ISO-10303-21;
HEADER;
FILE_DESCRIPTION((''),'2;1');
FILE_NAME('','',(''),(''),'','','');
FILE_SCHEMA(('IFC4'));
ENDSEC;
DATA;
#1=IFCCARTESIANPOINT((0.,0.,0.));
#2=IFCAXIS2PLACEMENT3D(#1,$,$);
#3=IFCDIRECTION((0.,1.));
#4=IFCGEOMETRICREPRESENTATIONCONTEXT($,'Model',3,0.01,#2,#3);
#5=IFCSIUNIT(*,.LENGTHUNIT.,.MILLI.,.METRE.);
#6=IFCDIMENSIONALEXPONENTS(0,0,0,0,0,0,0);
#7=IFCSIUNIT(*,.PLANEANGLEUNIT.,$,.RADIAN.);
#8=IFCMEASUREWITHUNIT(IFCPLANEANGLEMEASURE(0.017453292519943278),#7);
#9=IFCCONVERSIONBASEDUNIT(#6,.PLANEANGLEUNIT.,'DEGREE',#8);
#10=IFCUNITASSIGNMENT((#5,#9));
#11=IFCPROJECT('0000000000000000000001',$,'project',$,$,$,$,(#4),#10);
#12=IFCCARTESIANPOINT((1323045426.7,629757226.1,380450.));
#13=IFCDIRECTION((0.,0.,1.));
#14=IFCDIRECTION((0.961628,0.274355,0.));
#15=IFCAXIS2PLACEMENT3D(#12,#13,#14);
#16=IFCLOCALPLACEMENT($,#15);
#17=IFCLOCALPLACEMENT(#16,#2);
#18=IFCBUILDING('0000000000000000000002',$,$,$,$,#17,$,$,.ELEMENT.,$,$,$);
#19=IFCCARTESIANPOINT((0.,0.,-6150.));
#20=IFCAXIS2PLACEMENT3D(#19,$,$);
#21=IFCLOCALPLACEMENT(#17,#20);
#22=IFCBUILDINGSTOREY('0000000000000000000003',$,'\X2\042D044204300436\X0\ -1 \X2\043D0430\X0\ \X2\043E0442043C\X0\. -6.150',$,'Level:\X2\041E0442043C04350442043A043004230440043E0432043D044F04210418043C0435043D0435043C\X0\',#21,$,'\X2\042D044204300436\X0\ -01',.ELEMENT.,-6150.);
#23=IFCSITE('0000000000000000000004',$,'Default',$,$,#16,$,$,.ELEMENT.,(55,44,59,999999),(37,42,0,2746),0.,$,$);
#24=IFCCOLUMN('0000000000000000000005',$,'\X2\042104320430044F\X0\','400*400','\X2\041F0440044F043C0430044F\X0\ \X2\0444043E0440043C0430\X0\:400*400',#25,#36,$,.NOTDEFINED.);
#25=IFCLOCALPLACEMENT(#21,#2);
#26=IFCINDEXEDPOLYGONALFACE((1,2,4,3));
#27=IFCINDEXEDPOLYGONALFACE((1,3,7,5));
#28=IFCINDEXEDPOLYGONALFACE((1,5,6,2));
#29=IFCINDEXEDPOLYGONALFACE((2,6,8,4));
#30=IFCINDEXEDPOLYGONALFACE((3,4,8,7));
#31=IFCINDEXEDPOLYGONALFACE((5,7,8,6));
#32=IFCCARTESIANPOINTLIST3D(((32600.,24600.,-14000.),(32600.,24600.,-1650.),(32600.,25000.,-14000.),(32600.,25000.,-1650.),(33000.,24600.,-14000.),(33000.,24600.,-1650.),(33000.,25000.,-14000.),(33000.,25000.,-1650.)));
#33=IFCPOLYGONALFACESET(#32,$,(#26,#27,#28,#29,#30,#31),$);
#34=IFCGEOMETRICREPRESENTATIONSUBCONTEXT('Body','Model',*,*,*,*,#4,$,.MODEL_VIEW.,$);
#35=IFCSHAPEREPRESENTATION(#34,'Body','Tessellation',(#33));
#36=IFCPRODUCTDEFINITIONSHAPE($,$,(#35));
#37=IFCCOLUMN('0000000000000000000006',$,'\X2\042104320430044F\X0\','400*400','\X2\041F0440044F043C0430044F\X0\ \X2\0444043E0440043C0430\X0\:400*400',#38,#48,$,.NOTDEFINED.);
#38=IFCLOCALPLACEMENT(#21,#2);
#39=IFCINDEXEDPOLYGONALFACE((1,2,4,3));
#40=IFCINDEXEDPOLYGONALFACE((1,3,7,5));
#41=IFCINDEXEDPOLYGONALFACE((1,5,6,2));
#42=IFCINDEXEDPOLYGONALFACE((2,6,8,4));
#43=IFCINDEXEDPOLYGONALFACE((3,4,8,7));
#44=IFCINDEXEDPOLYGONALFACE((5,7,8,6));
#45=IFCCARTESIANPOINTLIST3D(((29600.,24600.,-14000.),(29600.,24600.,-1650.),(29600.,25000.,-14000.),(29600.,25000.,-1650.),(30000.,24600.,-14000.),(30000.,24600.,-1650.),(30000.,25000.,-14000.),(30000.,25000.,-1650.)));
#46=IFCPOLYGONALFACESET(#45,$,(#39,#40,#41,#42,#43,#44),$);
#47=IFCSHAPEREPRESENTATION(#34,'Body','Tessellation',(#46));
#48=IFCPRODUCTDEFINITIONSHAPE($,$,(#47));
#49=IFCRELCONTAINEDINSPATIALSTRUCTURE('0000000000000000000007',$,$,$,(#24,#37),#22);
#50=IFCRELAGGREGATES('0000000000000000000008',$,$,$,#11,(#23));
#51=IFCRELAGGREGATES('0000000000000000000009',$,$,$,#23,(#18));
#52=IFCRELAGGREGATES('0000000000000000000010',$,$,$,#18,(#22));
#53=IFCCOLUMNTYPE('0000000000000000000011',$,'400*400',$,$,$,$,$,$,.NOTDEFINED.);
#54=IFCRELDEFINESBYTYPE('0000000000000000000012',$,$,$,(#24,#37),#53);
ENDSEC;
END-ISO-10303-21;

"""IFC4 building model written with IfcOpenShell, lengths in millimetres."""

from ifc_helpers import new_model, entity, si_unit, converted_unit, direction, frame, origin, place, context, subcontext, project, spatial, indexed_curve, outline, extrude, type_object, element, save


model = new_model("IFC4")

# Units and contexts
model_context = context("Model", 3, precision=0.01, world=origin(), true_north=direction((0.0, 1.0)))
body_context = subcontext(model_context, "Body", "Model", "MODEL_VIEW")
ifc_project = project(units=[si_unit("LENGTHUNIT", "METRE", prefix="MILLI"), converted_unit("PLANEANGLEUNIT", "DEGREE", entity("IfcPlaneAngleMeasure", 0.017453292519943278), si_unit("PLANEANGLEUNIT", "RADIAN"), dimensions=[0, 0, 0, 0, 0, 0, 0])], contexts=[model_context])

# Site, building, storey
site_placement = place(None, frame((1323045426.7, 629757226.1, 380450.0), z_axis=(0.0, 0.0, 1.0), x_axis=(0.961628, 0.274355, 0.0)))
site = spatial("IfcSite", under=ifc_project, at=site_placement, Name="Default", CompositionType="ELEMENT", RefLatitude=(55, 44, 59, 999999), RefLongitude=(37, 42, 0, 2746), RefElevation=0.0)
building_placement = place(site_placement, origin())
building = spatial("IfcBuilding", under=site, at=building_placement, CompositionType="ELEMENT")
storey_placement = place(building_placement, frame((0.0, 0.0, -6150.0)))
storey = spatial("IfcBuildingStorey", under=building, at=storey_placement, Name="Этаж -1 на отм. -6.150", ObjectType="Level:ОтметкаУровняСИменем", LongName="Этаж -01", CompositionType="ELEMENT", Elevation=-6150.0)

# Columns
column_type = type_object("IfcColumnType", Name="400*400", PredefinedType="NOTDEFINED")
column_1_placement = place(storey_placement, origin())
element("IfcColumn", 1, at=column_1_placement, inside=storey, type_object=column_type, Name="Свая", Description="400*400", ObjectType="Прямая форма:400*400", PredefinedType="NOTDEFINED", context=body_context, shape_type="SweptSolid", body=[
    extrude(outline(indexed_curve([(-200.0, -200.0), (200.0, -200.0), (200.0, 200.0), (-200.0, 200.0), (-200.0, -200.0)], self_intersect=False)), frame((32800.0, 24800.0, -14000.0), z_axis=(0.0, 0.0, 1.0), x_axis=(0.0, 1.0, 0.0)), (0.0, 0.0, 1.0), 12350.0),
])
column_2_placement = place(storey_placement, origin())
element("IfcColumn", 2, at=column_2_placement, inside=storey, type_object=column_type, Name="Свая", Description="400*400", ObjectType="Прямая форма:400*400", PredefinedType="NOTDEFINED", context=body_context, shape_type="SweptSolid", body=[
    extrude(outline(indexed_curve([(-200.0, -200.0), (200.0, -200.0), (200.0, 200.0), (-200.0, 200.0), (-200.0, -200.0)], self_intersect=False)), frame((29800.0, 24800.0, -14000.0), z_axis=(0.0, 0.0, 1.0), x_axis=(0.0, 1.0, 0.0)), (0.0, 0.0, 1.0), 12350.0),
])

save(model, "model.ifc")
